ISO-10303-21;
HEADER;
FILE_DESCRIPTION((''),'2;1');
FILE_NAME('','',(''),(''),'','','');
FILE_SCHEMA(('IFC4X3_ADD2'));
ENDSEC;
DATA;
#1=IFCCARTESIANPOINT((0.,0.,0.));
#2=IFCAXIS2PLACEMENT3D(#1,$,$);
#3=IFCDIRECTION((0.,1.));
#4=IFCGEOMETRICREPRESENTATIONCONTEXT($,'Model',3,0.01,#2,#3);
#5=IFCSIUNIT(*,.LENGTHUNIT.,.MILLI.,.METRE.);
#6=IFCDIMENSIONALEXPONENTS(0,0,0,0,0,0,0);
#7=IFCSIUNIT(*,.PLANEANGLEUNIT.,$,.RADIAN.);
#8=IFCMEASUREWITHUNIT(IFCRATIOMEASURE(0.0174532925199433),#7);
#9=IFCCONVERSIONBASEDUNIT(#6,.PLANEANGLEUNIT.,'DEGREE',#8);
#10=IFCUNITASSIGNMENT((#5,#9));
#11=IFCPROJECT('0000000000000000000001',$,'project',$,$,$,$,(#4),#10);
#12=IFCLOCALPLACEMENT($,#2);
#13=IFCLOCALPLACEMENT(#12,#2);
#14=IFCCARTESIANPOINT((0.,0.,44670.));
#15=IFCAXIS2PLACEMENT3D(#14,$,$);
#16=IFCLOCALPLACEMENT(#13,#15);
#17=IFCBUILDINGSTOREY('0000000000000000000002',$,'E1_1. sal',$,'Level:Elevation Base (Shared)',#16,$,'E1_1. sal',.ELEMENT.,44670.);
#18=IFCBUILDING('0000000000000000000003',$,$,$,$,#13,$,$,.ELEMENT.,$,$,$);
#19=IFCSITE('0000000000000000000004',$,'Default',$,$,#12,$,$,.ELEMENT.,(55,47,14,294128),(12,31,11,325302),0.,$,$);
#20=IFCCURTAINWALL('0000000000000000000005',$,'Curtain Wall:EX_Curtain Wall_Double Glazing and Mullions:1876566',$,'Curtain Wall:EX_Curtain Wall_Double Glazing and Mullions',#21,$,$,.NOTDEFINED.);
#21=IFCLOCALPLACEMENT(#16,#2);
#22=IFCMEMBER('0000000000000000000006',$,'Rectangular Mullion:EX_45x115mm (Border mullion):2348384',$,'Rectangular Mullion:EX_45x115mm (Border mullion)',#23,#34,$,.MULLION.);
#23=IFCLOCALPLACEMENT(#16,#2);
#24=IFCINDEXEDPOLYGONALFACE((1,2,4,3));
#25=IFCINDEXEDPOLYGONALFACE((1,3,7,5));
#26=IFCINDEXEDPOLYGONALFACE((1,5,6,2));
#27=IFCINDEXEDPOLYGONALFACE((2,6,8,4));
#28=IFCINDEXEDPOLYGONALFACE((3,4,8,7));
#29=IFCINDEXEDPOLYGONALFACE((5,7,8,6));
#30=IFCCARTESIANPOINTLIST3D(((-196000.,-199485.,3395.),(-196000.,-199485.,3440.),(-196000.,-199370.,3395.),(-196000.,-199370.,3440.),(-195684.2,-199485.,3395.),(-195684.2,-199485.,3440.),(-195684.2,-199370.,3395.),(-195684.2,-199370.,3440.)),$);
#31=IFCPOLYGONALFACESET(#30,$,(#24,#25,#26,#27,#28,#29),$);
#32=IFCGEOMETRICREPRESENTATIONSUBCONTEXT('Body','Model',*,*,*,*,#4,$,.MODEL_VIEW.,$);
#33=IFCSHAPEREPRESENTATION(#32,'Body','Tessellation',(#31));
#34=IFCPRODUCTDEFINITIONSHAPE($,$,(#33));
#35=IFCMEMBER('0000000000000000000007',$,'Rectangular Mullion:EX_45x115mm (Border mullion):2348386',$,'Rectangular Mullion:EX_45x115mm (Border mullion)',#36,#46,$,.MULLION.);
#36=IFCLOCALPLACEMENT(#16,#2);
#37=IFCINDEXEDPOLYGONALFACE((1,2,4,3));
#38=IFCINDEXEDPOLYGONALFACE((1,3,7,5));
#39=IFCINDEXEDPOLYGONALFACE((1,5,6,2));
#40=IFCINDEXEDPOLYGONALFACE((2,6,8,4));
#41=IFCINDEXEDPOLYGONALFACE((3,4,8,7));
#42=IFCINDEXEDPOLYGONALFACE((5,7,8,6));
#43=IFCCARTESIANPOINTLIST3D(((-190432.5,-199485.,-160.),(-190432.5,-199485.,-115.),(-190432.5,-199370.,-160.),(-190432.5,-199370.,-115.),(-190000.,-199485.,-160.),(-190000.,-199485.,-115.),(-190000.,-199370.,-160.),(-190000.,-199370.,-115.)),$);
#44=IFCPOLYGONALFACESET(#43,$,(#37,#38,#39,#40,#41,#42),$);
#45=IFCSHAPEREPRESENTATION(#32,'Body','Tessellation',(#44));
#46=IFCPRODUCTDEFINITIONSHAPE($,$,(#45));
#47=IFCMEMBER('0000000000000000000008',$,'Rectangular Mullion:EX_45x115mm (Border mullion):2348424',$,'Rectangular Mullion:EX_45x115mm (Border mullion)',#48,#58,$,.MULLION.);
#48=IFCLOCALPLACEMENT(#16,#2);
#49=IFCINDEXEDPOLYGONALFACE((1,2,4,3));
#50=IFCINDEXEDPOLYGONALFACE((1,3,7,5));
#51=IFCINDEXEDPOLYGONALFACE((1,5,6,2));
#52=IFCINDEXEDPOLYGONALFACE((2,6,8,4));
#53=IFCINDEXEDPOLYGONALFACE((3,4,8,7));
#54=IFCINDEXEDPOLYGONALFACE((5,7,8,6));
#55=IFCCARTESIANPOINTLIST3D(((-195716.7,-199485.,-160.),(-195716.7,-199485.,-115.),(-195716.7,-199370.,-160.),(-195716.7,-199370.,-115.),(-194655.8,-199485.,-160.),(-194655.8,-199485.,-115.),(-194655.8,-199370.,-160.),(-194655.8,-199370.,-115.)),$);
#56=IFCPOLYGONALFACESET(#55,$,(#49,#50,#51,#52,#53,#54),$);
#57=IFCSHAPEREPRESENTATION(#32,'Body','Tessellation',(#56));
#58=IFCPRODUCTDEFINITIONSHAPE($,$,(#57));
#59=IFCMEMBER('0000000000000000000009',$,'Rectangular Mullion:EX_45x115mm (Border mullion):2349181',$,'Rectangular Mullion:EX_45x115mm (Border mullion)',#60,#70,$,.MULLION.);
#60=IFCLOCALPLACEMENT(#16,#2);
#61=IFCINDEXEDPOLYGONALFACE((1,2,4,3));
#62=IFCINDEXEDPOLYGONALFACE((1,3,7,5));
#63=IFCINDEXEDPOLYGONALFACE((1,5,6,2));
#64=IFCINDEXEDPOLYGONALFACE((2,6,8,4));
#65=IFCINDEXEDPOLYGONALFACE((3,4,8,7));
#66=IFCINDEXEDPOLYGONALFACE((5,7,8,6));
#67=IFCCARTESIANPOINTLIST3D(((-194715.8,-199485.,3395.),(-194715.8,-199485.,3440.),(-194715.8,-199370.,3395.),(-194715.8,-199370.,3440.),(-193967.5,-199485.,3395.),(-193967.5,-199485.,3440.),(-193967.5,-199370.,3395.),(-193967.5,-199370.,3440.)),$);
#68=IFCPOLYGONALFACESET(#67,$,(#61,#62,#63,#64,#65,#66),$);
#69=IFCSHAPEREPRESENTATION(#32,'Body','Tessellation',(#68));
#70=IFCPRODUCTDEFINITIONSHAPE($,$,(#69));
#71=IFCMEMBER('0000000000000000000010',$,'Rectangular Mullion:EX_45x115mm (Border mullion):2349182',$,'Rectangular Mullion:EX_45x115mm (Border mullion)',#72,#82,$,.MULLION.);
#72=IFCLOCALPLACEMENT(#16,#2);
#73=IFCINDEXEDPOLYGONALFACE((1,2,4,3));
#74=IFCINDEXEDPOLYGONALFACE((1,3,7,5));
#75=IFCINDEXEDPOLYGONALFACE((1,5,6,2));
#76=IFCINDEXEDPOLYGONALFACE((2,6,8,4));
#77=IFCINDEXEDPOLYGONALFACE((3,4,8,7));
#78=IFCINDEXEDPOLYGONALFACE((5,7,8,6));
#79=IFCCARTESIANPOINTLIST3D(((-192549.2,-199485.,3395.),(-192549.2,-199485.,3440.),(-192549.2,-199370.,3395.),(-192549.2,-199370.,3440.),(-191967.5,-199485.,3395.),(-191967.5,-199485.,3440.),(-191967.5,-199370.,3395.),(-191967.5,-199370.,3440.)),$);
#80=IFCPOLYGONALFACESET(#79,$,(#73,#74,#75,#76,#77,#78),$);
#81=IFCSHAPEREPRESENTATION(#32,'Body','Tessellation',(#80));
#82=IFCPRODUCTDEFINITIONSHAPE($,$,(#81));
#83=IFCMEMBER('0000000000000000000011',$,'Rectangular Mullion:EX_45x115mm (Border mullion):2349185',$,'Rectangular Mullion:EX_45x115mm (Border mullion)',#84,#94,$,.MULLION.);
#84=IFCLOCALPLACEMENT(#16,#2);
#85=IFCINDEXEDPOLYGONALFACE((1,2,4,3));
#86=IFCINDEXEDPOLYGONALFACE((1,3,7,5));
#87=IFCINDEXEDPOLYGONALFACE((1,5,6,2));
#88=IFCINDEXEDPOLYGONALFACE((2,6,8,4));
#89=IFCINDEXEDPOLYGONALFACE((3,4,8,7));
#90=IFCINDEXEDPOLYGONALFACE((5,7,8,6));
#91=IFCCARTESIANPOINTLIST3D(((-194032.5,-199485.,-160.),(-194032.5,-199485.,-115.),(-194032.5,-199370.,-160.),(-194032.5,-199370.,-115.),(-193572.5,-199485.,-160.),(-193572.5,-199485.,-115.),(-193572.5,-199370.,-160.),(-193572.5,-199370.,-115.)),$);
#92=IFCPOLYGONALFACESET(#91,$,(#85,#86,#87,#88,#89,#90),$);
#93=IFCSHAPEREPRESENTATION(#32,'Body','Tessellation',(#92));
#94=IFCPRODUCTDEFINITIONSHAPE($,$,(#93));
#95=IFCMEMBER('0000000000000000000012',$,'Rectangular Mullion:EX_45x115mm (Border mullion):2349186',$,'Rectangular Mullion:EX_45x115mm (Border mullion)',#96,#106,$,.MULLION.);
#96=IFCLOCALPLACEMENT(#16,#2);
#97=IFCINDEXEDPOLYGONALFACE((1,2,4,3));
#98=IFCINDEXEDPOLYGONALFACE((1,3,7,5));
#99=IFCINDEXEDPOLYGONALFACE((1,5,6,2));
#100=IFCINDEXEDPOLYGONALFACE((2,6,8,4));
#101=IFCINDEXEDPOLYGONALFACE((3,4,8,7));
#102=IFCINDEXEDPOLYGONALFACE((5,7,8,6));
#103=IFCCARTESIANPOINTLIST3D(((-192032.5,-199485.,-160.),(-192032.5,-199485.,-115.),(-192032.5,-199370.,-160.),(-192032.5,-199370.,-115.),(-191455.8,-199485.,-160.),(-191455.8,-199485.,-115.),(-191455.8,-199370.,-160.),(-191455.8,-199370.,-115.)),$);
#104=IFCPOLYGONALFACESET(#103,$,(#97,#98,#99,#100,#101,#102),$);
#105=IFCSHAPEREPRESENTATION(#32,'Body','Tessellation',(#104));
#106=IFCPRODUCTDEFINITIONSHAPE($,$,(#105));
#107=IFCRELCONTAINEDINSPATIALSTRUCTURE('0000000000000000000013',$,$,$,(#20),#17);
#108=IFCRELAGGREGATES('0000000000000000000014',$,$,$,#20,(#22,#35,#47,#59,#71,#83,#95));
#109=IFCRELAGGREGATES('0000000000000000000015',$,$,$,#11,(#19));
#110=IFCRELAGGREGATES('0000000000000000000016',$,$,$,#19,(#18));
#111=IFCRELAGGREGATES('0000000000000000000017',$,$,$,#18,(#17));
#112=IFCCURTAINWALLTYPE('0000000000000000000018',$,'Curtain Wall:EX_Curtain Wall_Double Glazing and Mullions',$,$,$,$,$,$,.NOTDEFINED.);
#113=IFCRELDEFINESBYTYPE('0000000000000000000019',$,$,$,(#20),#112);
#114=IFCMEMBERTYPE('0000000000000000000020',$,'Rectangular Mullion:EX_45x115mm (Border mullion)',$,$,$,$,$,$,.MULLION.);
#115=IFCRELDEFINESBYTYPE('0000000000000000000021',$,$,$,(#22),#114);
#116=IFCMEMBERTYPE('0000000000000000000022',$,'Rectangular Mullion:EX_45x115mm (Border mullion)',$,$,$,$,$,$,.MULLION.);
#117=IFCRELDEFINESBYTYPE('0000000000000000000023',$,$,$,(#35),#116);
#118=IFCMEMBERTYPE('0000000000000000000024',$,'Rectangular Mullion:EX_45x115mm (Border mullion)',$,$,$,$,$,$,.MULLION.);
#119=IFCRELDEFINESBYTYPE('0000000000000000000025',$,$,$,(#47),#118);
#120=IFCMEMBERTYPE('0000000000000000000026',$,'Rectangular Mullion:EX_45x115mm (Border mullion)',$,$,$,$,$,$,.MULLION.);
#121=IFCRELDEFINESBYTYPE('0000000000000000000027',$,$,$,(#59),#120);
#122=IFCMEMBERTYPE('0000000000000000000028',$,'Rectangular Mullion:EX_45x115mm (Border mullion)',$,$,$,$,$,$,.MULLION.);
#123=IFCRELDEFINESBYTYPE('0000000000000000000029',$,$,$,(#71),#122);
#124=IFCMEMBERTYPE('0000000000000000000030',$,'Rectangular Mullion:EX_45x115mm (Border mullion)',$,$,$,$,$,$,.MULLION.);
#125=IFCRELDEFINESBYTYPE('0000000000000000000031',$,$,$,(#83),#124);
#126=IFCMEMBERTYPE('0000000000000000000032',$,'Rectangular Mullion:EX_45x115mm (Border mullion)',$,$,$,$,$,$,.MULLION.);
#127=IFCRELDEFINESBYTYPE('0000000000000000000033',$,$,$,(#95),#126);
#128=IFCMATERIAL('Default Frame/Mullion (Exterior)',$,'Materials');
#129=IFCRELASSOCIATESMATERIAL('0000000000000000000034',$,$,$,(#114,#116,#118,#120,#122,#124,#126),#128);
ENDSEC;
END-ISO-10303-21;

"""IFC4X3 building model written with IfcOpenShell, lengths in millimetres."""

from ifc_helpers import new_model, entity, si_unit, converted_unit, direction, frame, origin, origin_2d_with_axis, place, context, subcontext, project, spatial, rectangle, extrude, source, transform, mapped, material, material_profile, profile_set, type_object, type_shapes, element, aggregate, save


model = new_model("IFC4X3")

# Units and contexts
model_context = context("Model", 3, precision=0.01, world=origin(), true_north=direction((0.0, 1.0)))
body_context = subcontext(model_context, "Body", "Model", "MODEL_VIEW")
ifc_project = project(units=[si_unit("LENGTHUNIT", "METRE", prefix="MILLI"), converted_unit("PLANEANGLEUNIT", "DEGREE", entity("IfcRatioMeasure", 0.0174532925199433), si_unit("PLANEANGLEUNIT", "RADIAN"), dimensions=[0, 0, 0, 0, 0, 0, 0])], contexts=[model_context])

# Site, building, storey
site_placement = place(None, origin())
site = spatial("IfcSite", under=ifc_project, at=site_placement, Name="Default", CompositionType="ELEMENT", RefLatitude=(55, 47, 14, 294128), RefLongitude=(12, 31, 11, 325302), RefElevation=0.0)
building_placement = place(site_placement, origin())
building = spatial("IfcBuilding", under=site, at=building_placement, CompositionType="ELEMENT")
storey_placement = place(building_placement, frame((0.0, 0.0, 44670.0)))
storey = spatial("IfcBuildingStorey", under=building, at=storey_placement, Name="E1_1. sal", ObjectType="Level:Elevation Base (Shared)", LongName="E1_1. sal", CompositionType="ELEMENT", Elevation=44670.0)

# Curtain wall, members
curtain_wall_type = type_object("IfcCurtainWallType", Name="Curtain Wall:EX_Curtain Wall_Double Glazing and Mullions", PredefinedType="NOTDEFINED")
curtain_wall_placement = place(storey_placement, frame((0.0, 0.0, -44670.0)))
curtain_wall = element("IfcCurtainWall", 1, at=curtain_wall_placement, inside=storey, type_object=curtain_wall_type, Name="Curtain Wall:EX_Curtain Wall_Double Glazing and Mullions:1876566", ObjectType="Curtain Wall:EX_Curtain Wall_Double Glazing and Mullions", PredefinedType="NOTDEFINED")
ifc_material_1 = material(Name="Default Frame/Mullion (Exterior)", Category="Materials")
ifc_material_profile_1 = material_profile(ifc_material_1, rectangle(XDim=115.0, YDim=45.0, at=origin_2d_with_axis()), Name="EX_45x115mm (Border mullion)")
ifc_profile_set_1 = profile_set([ifc_material_profile_1], Name="EX_45x115mm (Border mullion)")
member_type_1 = type_object("IfcMemberType", Name="Rectangular Mullion:EX_45x115mm (Border mullion)", PredefinedType="MULLION", material=ifc_profile_set_1)
shared_shape_1 = source(origin(), body_context, "Body", "SweptSolid", [
    extrude(rectangle(XDim=115.0, YDim=45.0, at=origin_2d_with_axis()), frame((-22.5, -57.5, -315.8), z_axis=(0.0, 0.0, 1.0), x_axis=(0.0, -1.0, 0.0)), (0.0, 0.0, 1.0), 315.8),
])
type_shapes(member_type_1, [shared_shape_1])
member_1_placement = place(curtain_wall_placement, frame((-195684.2, -199485.0, 48110.0), z_axis=(1.0, 0.0, 0.0), x_axis=(0.0, 0.0, 1.0)))
member_1 = element("IfcMember", 2, at=member_1_placement, type_object=member_type_1, Name="Rectangular Mullion:EX_45x115mm (Border mullion):2348384", ObjectType="Rectangular Mullion:EX_45x115mm (Border mullion)", PredefinedType="MULLION", context=body_context, shape_type="MappedRepresentation", body=[
    mapped(shared_shape_1, transform((0.0, 0.0, 0.0), scale=1.0)),
])
member_type_2 = type_object("IfcMemberType", Name="Rectangular Mullion:EX_45x115mm (Border mullion)", PredefinedType="MULLION", material=ifc_profile_set_1)
shared_shape_2 = source(origin(), body_context, "Body", "SweptSolid", [
    extrude(rectangle(XDim=115.0, YDim=45.0, at=origin_2d_with_axis()), frame((-22.5, -57.5, -432.5), z_axis=(0.0, 0.0, 1.0), x_axis=(0.0, -1.0, 0.0)), (0.0, 0.0, 1.0), 432.5),
])
type_shapes(member_type_2, [shared_shape_2])
member_2_placement = place(curtain_wall_placement, frame((-190432.5, -199485.0, 44510.0), z_axis=(-1.0, 0.0, 0.0), x_axis=(0.0, 0.0, -1.0)))
member_2 = element("IfcMember", 3, at=member_2_placement, type_object=member_type_2, Name="Rectangular Mullion:EX_45x115mm (Border mullion):2348386", ObjectType="Rectangular Mullion:EX_45x115mm (Border mullion)", PredefinedType="MULLION", context=body_context, shape_type="MappedRepresentation", body=[
    mapped(shared_shape_2, transform((0.0, 0.0, 0.0), scale=1.0)),
])
member_type_3 = type_object("IfcMemberType", Name="Rectangular Mullion:EX_45x115mm (Border mullion)", PredefinedType="MULLION", material=ifc_profile_set_1)
shared_shape_3 = source(origin(), body_context, "Body", "SweptSolid", [
    extrude(rectangle(XDim=115.0, YDim=45.0, at=origin_2d_with_axis()), frame((-22.5, -57.5, -1060.8), z_axis=(0.0, 0.0, 1.0), x_axis=(0.0, -1.0, 0.0)), (0.0, 0.0, 1.0), 1060.8),
])
type_shapes(member_type_3, [shared_shape_3])
member_3_placement = place(curtain_wall_placement, frame((-195716.7, -199485.0, 44510.0), z_axis=(-1.0, 0.0, 0.0), x_axis=(0.0, 0.0, -1.0)))
member_3 = element("IfcMember", 4, at=member_3_placement, type_object=member_type_3, Name="Rectangular Mullion:EX_45x115mm (Border mullion):2348424", ObjectType="Rectangular Mullion:EX_45x115mm (Border mullion)", PredefinedType="MULLION", context=body_context, shape_type="MappedRepresentation", body=[
    mapped(shared_shape_3, transform((0.0, 0.0, 0.0), scale=1.0)),
])
member_type_4 = type_object("IfcMemberType", Name="Rectangular Mullion:EX_45x115mm (Border mullion)", PredefinedType="MULLION", material=ifc_profile_set_1)
shared_shape_4 = source(origin(), body_context, "Body", "SweptSolid", [
    extrude(rectangle(XDim=115.0, YDim=45.0, at=origin_2d_with_axis()), frame((-22.5, -57.5, -748.3), z_axis=(0.0, 0.0, 1.0), x_axis=(0.0, -1.0, 0.0)), (0.0, 0.0, 1.0), 748.3),
])
type_shapes(member_type_4, [shared_shape_4])
member_4_placement = place(curtain_wall_placement, frame((-193967.5, -199485.0, 48110.0), z_axis=(1.0, 0.0, 0.0), x_axis=(0.0, 0.0, 1.0)))
member_4 = element("IfcMember", 5, at=member_4_placement, type_object=member_type_4, Name="Rectangular Mullion:EX_45x115mm (Border mullion):2349181", ObjectType="Rectangular Mullion:EX_45x115mm (Border mullion)", PredefinedType="MULLION", context=body_context, shape_type="MappedRepresentation", body=[
    mapped(shared_shape_4, transform((0.0, 0.0, 0.0), scale=1.0)),
])
member_type_5 = type_object("IfcMemberType", Name="Rectangular Mullion:EX_45x115mm (Border mullion)", PredefinedType="MULLION", material=ifc_profile_set_1)
shared_shape_5 = source(origin(), body_context, "Body", "SweptSolid", [
    extrude(rectangle(XDim=115.0, YDim=45.0, at=origin_2d_with_axis()), frame((-22.5, -57.5, -581.7), z_axis=(0.0, 0.0, 1.0), x_axis=(0.0, -1.0, 0.0)), (0.0, 0.0, 1.0), 581.7),
])
type_shapes(member_type_5, [shared_shape_5])
member_5_placement = place(curtain_wall_placement, frame((-191967.5, -199485.0, 48110.0), z_axis=(1.0, 0.0, 0.0), x_axis=(0.0, 0.0, 1.0)))
member_5 = element("IfcMember", 6, at=member_5_placement, type_object=member_type_5, Name="Rectangular Mullion:EX_45x115mm (Border mullion):2349182", ObjectType="Rectangular Mullion:EX_45x115mm (Border mullion)", PredefinedType="MULLION", context=body_context, shape_type="MappedRepresentation", body=[
    mapped(shared_shape_5, transform((0.0, 0.0, 0.0), scale=1.0)),
])
member_type_6 = type_object("IfcMemberType", Name="Rectangular Mullion:EX_45x115mm (Border mullion)", PredefinedType="MULLION", material=ifc_profile_set_1)
shared_shape_6 = source(origin(), body_context, "Body", "SweptSolid", [
    extrude(rectangle(XDim=115.0, YDim=45.0, at=origin_2d_with_axis()), frame((-22.5, -57.5, -460.0), z_axis=(0.0, 0.0, 1.0), x_axis=(0.0, -1.0, 0.0)), (0.0, 0.0, 1.0), 460.0),
])
type_shapes(member_type_6, [shared_shape_6])
member_6_placement = place(curtain_wall_placement, frame((-194032.5, -199485.0, 44510.0), z_axis=(-1.0, 0.0, 0.0), x_axis=(0.0, 0.0, -1.0)))
member_6 = element("IfcMember", 7, at=member_6_placement, type_object=member_type_6, Name="Rectangular Mullion:EX_45x115mm (Border mullion):2349185", ObjectType="Rectangular Mullion:EX_45x115mm (Border mullion)", PredefinedType="MULLION", context=body_context, shape_type="MappedRepresentation", body=[
    mapped(shared_shape_6, transform((0.0, 0.0, 0.0), scale=1.0)),
])
member_type_7 = type_object("IfcMemberType", Name="Rectangular Mullion:EX_45x115mm (Border mullion)", PredefinedType="MULLION", material=ifc_profile_set_1)
shared_shape_7 = source(origin(), body_context, "Body", "SweptSolid", [
    extrude(rectangle(XDim=115.0, YDim=45.0, at=origin_2d_with_axis()), frame((-22.5, -57.5, -576.7), z_axis=(0.0, 0.0, 1.0), x_axis=(0.0, -1.0, 0.0)), (0.0, 0.0, 1.0), 576.7),
])
type_shapes(member_type_7, [shared_shape_7])
member_7_placement = place(curtain_wall_placement, frame((-192032.5, -199485.0, 44510.0), z_axis=(-1.0, 0.0, 0.0), x_axis=(0.0, 0.0, -1.0)))
member_7 = element("IfcMember", 8, at=member_7_placement, type_object=member_type_7, Name="Rectangular Mullion:EX_45x115mm (Border mullion):2349186", ObjectType="Rectangular Mullion:EX_45x115mm (Border mullion)", PredefinedType="MULLION", context=body_context, shape_type="MappedRepresentation", body=[
    mapped(shared_shape_7, transform((0.0, 0.0, 0.0), scale=1.0)),
])
aggregate(curtain_wall, [member_1, member_2, member_3, member_4, member_5, member_6, member_7])

save(model, "model.ifc")
